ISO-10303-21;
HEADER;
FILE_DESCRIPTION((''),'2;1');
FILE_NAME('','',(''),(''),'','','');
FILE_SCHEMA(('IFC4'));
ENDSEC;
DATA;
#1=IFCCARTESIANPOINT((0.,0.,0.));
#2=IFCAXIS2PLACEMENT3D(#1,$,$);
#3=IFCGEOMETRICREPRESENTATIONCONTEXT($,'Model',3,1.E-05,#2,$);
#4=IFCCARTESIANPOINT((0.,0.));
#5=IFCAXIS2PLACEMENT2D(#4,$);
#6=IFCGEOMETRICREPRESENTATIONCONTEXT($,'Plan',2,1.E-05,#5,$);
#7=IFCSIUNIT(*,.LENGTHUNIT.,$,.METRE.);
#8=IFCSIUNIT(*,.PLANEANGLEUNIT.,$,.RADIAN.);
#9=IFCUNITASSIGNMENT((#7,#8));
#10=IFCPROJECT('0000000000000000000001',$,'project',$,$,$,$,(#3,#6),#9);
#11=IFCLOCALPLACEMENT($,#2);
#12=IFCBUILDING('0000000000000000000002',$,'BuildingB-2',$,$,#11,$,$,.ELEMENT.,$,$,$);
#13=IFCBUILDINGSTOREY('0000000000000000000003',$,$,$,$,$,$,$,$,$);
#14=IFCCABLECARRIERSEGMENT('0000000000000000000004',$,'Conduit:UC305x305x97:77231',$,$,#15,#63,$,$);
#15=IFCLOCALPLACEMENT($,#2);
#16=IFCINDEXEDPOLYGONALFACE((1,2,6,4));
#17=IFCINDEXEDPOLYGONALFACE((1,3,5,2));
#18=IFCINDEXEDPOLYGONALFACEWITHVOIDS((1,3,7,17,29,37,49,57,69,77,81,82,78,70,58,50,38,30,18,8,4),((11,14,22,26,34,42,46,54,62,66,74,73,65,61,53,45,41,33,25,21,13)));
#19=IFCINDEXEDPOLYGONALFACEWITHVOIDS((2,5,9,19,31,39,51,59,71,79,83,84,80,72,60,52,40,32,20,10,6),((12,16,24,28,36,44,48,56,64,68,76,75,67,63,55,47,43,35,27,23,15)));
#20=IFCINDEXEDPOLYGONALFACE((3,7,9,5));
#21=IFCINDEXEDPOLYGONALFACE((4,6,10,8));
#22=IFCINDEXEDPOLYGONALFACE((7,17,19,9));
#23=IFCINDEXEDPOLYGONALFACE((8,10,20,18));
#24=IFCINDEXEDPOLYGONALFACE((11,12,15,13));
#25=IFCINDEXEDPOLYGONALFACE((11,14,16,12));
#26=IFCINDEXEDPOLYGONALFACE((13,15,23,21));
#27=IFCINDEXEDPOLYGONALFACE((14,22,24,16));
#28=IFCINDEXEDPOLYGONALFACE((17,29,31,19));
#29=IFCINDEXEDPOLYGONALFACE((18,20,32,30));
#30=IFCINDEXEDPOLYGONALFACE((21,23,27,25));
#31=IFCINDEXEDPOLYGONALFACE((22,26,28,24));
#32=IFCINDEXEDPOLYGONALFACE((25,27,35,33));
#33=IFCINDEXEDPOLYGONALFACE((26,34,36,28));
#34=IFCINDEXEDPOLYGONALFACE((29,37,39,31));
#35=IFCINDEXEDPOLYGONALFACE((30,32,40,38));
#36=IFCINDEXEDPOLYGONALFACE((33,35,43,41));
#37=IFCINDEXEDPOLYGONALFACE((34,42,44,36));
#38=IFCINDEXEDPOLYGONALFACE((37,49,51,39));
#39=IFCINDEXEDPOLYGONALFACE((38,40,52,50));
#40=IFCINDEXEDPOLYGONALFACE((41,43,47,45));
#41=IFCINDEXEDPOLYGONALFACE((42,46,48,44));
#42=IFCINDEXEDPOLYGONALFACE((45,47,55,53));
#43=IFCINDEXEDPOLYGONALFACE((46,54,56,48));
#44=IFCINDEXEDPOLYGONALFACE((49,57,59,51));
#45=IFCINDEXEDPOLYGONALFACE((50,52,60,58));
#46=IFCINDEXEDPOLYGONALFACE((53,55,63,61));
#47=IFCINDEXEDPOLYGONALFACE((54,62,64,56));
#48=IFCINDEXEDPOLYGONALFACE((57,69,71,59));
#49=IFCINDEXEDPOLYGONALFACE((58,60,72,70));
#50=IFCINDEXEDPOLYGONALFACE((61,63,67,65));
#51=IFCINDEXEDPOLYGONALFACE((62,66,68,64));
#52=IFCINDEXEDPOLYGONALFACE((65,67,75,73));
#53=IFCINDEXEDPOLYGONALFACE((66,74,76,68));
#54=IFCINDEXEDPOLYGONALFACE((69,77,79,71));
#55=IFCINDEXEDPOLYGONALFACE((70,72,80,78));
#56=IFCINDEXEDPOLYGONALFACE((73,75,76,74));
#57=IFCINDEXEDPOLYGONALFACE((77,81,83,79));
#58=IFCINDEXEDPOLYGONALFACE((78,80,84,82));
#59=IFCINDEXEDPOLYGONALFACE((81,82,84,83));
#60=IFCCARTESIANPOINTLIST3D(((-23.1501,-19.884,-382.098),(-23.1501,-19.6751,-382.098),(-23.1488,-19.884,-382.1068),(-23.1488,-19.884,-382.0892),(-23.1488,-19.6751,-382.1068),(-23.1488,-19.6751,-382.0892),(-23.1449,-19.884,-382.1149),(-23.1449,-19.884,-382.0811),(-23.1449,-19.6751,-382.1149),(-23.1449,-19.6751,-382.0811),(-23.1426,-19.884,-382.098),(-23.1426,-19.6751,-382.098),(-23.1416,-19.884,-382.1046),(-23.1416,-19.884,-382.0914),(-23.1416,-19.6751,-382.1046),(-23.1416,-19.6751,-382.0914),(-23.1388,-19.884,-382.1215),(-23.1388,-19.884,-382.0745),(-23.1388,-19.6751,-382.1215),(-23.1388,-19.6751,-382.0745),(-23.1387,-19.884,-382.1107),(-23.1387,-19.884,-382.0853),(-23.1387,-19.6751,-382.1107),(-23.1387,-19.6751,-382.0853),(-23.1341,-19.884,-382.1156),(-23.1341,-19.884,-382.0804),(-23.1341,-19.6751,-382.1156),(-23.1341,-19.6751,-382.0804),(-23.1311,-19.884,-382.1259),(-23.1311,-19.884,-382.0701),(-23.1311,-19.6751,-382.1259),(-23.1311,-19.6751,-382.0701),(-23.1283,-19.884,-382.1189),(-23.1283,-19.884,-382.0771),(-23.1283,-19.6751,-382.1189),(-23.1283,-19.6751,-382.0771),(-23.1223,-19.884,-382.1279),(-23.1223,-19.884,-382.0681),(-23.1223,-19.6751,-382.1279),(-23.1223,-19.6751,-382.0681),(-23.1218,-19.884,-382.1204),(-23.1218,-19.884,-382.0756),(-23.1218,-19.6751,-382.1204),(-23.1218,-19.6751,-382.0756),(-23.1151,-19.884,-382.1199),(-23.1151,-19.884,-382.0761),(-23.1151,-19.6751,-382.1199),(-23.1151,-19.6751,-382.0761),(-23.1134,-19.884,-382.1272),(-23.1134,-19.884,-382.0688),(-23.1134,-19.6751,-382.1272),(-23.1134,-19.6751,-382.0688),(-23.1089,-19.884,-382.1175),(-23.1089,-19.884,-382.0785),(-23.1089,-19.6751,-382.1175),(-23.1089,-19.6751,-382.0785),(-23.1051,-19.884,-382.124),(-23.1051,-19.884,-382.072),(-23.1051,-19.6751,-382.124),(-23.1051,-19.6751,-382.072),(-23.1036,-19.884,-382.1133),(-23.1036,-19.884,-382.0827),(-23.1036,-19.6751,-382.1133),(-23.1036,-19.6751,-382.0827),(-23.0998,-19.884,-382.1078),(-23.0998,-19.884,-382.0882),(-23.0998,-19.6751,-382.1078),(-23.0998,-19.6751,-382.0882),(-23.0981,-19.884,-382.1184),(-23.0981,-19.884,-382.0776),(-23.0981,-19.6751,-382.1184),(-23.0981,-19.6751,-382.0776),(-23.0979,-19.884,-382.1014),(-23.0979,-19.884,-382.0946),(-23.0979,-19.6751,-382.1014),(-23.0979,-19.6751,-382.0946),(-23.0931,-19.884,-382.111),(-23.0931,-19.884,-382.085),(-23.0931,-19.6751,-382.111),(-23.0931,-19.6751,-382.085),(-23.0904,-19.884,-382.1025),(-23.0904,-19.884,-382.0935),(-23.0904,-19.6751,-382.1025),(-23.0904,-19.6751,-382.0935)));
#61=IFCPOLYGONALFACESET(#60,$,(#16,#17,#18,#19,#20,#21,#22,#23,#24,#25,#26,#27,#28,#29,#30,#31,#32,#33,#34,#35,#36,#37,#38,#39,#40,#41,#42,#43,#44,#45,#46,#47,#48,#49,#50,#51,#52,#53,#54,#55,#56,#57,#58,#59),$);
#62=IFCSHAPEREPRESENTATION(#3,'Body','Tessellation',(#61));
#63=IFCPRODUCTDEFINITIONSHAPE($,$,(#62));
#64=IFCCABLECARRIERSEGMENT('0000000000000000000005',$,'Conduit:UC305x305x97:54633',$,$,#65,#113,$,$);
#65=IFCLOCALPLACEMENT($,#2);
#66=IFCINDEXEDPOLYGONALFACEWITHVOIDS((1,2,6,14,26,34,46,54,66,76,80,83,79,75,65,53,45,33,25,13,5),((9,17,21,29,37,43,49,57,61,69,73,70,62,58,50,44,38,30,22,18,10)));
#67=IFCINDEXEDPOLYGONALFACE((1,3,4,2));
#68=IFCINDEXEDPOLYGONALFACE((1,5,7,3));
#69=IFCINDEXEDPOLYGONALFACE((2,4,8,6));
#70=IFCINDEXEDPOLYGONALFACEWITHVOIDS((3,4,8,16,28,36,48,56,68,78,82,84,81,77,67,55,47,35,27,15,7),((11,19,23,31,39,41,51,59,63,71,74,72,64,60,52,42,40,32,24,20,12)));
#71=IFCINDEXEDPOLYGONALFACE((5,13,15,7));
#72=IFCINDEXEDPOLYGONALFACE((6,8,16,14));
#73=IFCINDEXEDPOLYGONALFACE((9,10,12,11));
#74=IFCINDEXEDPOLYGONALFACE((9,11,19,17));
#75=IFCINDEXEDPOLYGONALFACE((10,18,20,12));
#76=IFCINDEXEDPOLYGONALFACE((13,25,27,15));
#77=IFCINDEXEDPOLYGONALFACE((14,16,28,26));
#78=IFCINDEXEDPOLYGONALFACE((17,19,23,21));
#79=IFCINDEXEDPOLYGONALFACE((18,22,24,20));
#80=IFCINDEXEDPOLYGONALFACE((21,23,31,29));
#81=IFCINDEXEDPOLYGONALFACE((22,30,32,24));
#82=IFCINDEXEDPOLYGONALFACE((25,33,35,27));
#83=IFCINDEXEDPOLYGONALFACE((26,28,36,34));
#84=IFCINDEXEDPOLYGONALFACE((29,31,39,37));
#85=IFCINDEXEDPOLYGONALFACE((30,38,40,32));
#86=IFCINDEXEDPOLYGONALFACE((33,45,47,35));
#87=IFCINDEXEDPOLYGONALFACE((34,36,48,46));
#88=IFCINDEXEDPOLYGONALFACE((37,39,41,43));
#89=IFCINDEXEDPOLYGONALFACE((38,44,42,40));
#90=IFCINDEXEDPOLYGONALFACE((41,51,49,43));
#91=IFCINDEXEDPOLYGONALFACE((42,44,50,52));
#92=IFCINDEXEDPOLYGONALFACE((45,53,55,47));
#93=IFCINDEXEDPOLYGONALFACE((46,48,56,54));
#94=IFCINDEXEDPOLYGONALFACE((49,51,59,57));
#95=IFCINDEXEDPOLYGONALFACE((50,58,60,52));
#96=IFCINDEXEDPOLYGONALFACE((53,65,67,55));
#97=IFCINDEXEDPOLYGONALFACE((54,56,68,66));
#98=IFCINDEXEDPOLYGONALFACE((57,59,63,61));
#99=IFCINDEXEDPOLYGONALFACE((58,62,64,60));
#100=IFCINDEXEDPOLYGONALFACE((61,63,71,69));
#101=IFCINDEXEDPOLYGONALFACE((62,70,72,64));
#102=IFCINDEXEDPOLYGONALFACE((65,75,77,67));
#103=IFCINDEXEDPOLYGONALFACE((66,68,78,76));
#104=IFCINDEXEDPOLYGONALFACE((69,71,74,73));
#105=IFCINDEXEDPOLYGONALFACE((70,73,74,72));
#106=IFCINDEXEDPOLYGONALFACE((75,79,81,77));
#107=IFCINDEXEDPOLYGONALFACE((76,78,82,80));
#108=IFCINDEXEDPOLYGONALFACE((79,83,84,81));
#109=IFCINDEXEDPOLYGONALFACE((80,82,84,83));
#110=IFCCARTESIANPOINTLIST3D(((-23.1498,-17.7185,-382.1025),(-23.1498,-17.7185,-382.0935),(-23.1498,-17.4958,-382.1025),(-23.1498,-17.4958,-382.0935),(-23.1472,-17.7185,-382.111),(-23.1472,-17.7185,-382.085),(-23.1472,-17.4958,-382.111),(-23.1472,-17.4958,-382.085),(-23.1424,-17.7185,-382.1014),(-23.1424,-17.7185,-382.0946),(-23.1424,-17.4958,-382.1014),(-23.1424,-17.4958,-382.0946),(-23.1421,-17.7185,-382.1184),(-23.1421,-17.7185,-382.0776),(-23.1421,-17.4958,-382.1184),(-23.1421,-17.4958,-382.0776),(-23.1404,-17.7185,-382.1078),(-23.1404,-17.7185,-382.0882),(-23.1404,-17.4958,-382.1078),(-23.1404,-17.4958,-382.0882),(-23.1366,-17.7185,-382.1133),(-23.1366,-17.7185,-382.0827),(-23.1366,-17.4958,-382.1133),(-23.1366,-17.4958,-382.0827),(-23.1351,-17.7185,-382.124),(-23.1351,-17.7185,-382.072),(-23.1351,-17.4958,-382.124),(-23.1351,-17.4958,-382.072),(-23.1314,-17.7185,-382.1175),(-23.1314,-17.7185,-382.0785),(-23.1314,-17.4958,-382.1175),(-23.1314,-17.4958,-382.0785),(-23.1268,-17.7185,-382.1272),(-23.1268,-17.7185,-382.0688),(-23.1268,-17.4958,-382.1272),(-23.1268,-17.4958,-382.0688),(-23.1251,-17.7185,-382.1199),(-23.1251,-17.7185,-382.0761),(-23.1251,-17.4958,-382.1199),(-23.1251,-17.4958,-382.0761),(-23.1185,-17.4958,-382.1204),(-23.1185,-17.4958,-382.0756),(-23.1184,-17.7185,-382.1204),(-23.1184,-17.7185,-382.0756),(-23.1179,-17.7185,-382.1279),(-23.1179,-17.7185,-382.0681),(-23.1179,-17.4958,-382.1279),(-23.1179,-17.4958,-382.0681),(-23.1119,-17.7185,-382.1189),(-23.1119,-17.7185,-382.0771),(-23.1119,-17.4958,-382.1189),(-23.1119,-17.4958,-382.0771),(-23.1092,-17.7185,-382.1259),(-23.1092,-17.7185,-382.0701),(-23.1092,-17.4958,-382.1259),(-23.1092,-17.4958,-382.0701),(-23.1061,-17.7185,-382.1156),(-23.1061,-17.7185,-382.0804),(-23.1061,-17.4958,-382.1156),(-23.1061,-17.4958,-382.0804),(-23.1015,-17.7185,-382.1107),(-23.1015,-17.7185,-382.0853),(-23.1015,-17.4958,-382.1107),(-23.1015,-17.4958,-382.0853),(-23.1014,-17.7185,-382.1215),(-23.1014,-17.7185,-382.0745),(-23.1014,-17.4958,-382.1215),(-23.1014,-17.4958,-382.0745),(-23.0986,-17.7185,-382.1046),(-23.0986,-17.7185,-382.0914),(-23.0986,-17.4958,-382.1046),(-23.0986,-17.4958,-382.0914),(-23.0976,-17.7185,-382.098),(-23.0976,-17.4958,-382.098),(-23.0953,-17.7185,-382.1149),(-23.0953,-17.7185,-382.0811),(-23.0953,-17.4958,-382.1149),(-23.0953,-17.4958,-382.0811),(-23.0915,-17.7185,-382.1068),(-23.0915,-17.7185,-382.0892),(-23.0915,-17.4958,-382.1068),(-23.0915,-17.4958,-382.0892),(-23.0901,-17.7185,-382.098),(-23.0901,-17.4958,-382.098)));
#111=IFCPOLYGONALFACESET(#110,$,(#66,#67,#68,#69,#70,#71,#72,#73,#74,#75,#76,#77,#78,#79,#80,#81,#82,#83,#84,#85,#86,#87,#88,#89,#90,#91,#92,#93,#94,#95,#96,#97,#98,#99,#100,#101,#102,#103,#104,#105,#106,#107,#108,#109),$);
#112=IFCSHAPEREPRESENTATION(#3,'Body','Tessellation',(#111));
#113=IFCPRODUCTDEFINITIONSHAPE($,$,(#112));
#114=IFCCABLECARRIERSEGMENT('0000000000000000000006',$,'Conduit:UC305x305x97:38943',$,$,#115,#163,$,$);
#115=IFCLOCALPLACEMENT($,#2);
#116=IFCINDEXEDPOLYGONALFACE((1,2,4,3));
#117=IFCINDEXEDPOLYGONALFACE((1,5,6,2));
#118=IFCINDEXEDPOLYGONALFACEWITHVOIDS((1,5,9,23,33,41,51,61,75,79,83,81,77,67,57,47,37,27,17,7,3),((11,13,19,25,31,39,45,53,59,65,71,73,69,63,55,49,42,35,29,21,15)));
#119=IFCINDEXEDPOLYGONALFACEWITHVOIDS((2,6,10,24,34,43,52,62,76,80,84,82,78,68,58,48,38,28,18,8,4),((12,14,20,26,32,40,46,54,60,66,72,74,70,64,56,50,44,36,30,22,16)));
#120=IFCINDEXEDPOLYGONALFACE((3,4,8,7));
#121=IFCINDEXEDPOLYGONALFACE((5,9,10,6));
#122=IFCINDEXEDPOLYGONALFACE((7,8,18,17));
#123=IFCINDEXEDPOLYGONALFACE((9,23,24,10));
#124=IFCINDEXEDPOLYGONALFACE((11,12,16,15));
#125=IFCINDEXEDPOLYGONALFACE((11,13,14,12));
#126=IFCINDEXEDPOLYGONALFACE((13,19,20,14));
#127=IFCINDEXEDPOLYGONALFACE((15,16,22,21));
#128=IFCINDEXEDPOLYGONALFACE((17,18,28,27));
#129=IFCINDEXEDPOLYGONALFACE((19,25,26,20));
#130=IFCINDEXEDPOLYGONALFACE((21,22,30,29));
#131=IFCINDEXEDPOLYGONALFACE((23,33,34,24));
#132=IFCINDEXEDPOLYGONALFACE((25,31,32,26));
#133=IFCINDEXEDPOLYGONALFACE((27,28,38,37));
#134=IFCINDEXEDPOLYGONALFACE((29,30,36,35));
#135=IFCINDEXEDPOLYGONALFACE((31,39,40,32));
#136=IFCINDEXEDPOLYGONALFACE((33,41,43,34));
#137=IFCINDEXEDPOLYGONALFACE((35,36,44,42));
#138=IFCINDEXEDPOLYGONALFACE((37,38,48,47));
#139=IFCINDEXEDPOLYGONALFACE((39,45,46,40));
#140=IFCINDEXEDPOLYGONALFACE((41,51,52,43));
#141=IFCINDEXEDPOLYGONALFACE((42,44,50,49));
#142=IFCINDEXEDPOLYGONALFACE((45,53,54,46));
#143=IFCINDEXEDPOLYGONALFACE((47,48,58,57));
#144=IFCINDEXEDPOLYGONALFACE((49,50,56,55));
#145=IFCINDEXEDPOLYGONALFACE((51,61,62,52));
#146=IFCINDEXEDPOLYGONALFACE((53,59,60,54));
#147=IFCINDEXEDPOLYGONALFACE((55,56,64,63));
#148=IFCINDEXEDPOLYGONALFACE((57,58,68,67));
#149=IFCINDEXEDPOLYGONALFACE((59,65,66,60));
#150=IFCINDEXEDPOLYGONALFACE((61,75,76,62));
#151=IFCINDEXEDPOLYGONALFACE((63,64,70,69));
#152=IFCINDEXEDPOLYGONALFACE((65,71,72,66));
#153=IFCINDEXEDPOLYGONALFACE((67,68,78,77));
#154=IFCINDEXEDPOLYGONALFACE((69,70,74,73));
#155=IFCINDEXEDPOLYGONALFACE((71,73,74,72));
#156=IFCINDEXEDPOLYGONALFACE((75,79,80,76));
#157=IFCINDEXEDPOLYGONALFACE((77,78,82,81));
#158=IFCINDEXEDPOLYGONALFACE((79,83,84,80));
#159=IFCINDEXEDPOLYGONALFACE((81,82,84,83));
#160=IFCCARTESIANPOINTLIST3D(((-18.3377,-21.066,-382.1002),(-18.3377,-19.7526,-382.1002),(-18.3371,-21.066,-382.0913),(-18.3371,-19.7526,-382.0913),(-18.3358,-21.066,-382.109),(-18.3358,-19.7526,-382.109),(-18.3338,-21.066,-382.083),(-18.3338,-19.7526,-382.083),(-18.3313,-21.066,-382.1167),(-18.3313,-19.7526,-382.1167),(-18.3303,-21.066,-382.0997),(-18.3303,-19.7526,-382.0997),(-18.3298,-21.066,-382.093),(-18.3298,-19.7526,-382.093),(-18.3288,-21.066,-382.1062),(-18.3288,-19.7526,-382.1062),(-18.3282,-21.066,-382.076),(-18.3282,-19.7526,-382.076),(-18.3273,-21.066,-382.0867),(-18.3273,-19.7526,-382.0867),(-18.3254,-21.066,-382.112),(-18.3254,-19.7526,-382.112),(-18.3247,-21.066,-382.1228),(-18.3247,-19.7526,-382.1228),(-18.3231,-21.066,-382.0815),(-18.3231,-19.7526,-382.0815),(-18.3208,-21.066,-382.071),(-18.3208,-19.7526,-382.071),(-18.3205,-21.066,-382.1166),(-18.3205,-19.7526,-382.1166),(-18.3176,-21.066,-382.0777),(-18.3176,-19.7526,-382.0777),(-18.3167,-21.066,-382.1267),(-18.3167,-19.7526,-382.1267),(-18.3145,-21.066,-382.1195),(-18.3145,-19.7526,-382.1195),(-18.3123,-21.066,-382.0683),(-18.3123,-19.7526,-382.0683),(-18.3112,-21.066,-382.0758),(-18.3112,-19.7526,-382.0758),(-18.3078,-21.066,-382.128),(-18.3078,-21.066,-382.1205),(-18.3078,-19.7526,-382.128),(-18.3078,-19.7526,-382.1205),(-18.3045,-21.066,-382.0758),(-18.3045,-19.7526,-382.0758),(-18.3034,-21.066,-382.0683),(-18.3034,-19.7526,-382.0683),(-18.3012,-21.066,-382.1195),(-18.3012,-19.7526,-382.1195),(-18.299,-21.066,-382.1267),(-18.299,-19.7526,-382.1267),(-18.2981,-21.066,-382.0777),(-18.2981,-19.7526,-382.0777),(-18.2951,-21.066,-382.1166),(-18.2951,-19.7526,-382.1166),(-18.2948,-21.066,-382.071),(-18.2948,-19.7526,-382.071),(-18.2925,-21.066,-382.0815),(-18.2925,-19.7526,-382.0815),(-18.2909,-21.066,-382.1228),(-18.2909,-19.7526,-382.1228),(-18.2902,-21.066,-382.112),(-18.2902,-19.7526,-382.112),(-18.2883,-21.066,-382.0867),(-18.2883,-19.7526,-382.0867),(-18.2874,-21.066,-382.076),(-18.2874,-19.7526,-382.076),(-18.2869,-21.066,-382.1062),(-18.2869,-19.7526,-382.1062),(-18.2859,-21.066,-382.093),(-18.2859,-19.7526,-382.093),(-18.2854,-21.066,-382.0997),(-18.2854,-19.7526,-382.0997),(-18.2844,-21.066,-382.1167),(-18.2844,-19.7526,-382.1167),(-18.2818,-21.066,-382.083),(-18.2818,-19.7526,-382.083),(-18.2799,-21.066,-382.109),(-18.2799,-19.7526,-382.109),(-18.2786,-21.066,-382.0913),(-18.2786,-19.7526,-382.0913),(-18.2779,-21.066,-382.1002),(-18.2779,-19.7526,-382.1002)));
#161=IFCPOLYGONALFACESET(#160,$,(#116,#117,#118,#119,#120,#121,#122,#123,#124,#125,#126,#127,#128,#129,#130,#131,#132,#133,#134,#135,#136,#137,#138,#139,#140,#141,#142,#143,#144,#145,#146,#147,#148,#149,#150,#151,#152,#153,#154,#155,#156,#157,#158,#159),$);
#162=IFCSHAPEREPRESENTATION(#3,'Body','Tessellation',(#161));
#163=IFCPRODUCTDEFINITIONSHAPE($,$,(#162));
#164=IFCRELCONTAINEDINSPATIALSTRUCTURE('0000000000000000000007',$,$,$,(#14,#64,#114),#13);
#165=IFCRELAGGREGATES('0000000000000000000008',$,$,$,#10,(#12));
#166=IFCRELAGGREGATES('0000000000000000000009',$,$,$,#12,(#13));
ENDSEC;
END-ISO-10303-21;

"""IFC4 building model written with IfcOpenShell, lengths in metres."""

from ifc_helpers import new_model, entity, si_unit, origin, origin_2d, place, context, project, spatial, element, save


model = new_model("IFC4")

# Units and contexts
model_context = context("Model", 3, precision=1e-05, world=origin())
plan_context = context("Plan", 2, precision=1e-05, world=origin_2d())
ifc_project = project(units=[si_unit("LENGTHUNIT", "METRE"), si_unit("PLANEANGLEUNIT", "RADIAN")], contexts=[model_context, plan_context])

# Building, storey
building_placement = place(None, origin())
building = spatial("IfcBuilding", under=ifc_project, at=building_placement, Name="BuildingB-2", CompositionType="ELEMENT")
storey = spatial("IfcBuildingStorey", under=building)

# Cable carrier segments
element("IfcCableCarrierSegment", 1, inside=storey, Name="Conduit:UC305x305x97:77231", context=model_context, shape_type="AdvancedSweptSolid", body=[
    entity("IfcSweptDiskSolid", entity("IfcCompositeCurve", [entity("IfcCompositeCurveSegment", "CONTINUOUS", False, entity("IfcPolyline", [entity("IfcCartesianPoint", [23.1201, 19.884, 382.098]), entity("IfcCartesianPoint", [23.1201, 19.6751, 382.098])]))], False), 0.03, 0.0225),
])
element("IfcCableCarrierSegment", 2, inside=storey, Name="Conduit:UC305x305x97:54633", context=model_context, shape_type="AdvancedSweptSolid", body=[
    entity("IfcSweptDiskSolid", entity("IfcCompositeCurve", [entity("IfcCompositeCurveSegment", "CONTINUOUS", False, entity("IfcPolyline", [entity("IfcCartesianPoint", [23.1201, 17.4958, 382.098]), entity("IfcCartesianPoint", [23.1201, 17.7185, 382.098])]))], False), 0.03, 0.0225),
])
element("IfcCableCarrierSegment", 3, inside=storey, Name="Conduit:UC305x305x97:38943", context=model_context, shape_type="AdvancedSweptSolid", body=[
    entity("IfcSweptDiskSolid", entity("IfcCompositeCurve", [entity("IfcCompositeCurveSegment", "CONTINUOUS", False, entity("IfcPolyline", [entity("IfcCartesianPoint", [18.3078, 21.066, 382.098]), entity("IfcCartesianPoint", [18.3078, 19.7526, 382.098])]))], False), 0.03, 0.0225),
])

save(model, "model.ifc")
